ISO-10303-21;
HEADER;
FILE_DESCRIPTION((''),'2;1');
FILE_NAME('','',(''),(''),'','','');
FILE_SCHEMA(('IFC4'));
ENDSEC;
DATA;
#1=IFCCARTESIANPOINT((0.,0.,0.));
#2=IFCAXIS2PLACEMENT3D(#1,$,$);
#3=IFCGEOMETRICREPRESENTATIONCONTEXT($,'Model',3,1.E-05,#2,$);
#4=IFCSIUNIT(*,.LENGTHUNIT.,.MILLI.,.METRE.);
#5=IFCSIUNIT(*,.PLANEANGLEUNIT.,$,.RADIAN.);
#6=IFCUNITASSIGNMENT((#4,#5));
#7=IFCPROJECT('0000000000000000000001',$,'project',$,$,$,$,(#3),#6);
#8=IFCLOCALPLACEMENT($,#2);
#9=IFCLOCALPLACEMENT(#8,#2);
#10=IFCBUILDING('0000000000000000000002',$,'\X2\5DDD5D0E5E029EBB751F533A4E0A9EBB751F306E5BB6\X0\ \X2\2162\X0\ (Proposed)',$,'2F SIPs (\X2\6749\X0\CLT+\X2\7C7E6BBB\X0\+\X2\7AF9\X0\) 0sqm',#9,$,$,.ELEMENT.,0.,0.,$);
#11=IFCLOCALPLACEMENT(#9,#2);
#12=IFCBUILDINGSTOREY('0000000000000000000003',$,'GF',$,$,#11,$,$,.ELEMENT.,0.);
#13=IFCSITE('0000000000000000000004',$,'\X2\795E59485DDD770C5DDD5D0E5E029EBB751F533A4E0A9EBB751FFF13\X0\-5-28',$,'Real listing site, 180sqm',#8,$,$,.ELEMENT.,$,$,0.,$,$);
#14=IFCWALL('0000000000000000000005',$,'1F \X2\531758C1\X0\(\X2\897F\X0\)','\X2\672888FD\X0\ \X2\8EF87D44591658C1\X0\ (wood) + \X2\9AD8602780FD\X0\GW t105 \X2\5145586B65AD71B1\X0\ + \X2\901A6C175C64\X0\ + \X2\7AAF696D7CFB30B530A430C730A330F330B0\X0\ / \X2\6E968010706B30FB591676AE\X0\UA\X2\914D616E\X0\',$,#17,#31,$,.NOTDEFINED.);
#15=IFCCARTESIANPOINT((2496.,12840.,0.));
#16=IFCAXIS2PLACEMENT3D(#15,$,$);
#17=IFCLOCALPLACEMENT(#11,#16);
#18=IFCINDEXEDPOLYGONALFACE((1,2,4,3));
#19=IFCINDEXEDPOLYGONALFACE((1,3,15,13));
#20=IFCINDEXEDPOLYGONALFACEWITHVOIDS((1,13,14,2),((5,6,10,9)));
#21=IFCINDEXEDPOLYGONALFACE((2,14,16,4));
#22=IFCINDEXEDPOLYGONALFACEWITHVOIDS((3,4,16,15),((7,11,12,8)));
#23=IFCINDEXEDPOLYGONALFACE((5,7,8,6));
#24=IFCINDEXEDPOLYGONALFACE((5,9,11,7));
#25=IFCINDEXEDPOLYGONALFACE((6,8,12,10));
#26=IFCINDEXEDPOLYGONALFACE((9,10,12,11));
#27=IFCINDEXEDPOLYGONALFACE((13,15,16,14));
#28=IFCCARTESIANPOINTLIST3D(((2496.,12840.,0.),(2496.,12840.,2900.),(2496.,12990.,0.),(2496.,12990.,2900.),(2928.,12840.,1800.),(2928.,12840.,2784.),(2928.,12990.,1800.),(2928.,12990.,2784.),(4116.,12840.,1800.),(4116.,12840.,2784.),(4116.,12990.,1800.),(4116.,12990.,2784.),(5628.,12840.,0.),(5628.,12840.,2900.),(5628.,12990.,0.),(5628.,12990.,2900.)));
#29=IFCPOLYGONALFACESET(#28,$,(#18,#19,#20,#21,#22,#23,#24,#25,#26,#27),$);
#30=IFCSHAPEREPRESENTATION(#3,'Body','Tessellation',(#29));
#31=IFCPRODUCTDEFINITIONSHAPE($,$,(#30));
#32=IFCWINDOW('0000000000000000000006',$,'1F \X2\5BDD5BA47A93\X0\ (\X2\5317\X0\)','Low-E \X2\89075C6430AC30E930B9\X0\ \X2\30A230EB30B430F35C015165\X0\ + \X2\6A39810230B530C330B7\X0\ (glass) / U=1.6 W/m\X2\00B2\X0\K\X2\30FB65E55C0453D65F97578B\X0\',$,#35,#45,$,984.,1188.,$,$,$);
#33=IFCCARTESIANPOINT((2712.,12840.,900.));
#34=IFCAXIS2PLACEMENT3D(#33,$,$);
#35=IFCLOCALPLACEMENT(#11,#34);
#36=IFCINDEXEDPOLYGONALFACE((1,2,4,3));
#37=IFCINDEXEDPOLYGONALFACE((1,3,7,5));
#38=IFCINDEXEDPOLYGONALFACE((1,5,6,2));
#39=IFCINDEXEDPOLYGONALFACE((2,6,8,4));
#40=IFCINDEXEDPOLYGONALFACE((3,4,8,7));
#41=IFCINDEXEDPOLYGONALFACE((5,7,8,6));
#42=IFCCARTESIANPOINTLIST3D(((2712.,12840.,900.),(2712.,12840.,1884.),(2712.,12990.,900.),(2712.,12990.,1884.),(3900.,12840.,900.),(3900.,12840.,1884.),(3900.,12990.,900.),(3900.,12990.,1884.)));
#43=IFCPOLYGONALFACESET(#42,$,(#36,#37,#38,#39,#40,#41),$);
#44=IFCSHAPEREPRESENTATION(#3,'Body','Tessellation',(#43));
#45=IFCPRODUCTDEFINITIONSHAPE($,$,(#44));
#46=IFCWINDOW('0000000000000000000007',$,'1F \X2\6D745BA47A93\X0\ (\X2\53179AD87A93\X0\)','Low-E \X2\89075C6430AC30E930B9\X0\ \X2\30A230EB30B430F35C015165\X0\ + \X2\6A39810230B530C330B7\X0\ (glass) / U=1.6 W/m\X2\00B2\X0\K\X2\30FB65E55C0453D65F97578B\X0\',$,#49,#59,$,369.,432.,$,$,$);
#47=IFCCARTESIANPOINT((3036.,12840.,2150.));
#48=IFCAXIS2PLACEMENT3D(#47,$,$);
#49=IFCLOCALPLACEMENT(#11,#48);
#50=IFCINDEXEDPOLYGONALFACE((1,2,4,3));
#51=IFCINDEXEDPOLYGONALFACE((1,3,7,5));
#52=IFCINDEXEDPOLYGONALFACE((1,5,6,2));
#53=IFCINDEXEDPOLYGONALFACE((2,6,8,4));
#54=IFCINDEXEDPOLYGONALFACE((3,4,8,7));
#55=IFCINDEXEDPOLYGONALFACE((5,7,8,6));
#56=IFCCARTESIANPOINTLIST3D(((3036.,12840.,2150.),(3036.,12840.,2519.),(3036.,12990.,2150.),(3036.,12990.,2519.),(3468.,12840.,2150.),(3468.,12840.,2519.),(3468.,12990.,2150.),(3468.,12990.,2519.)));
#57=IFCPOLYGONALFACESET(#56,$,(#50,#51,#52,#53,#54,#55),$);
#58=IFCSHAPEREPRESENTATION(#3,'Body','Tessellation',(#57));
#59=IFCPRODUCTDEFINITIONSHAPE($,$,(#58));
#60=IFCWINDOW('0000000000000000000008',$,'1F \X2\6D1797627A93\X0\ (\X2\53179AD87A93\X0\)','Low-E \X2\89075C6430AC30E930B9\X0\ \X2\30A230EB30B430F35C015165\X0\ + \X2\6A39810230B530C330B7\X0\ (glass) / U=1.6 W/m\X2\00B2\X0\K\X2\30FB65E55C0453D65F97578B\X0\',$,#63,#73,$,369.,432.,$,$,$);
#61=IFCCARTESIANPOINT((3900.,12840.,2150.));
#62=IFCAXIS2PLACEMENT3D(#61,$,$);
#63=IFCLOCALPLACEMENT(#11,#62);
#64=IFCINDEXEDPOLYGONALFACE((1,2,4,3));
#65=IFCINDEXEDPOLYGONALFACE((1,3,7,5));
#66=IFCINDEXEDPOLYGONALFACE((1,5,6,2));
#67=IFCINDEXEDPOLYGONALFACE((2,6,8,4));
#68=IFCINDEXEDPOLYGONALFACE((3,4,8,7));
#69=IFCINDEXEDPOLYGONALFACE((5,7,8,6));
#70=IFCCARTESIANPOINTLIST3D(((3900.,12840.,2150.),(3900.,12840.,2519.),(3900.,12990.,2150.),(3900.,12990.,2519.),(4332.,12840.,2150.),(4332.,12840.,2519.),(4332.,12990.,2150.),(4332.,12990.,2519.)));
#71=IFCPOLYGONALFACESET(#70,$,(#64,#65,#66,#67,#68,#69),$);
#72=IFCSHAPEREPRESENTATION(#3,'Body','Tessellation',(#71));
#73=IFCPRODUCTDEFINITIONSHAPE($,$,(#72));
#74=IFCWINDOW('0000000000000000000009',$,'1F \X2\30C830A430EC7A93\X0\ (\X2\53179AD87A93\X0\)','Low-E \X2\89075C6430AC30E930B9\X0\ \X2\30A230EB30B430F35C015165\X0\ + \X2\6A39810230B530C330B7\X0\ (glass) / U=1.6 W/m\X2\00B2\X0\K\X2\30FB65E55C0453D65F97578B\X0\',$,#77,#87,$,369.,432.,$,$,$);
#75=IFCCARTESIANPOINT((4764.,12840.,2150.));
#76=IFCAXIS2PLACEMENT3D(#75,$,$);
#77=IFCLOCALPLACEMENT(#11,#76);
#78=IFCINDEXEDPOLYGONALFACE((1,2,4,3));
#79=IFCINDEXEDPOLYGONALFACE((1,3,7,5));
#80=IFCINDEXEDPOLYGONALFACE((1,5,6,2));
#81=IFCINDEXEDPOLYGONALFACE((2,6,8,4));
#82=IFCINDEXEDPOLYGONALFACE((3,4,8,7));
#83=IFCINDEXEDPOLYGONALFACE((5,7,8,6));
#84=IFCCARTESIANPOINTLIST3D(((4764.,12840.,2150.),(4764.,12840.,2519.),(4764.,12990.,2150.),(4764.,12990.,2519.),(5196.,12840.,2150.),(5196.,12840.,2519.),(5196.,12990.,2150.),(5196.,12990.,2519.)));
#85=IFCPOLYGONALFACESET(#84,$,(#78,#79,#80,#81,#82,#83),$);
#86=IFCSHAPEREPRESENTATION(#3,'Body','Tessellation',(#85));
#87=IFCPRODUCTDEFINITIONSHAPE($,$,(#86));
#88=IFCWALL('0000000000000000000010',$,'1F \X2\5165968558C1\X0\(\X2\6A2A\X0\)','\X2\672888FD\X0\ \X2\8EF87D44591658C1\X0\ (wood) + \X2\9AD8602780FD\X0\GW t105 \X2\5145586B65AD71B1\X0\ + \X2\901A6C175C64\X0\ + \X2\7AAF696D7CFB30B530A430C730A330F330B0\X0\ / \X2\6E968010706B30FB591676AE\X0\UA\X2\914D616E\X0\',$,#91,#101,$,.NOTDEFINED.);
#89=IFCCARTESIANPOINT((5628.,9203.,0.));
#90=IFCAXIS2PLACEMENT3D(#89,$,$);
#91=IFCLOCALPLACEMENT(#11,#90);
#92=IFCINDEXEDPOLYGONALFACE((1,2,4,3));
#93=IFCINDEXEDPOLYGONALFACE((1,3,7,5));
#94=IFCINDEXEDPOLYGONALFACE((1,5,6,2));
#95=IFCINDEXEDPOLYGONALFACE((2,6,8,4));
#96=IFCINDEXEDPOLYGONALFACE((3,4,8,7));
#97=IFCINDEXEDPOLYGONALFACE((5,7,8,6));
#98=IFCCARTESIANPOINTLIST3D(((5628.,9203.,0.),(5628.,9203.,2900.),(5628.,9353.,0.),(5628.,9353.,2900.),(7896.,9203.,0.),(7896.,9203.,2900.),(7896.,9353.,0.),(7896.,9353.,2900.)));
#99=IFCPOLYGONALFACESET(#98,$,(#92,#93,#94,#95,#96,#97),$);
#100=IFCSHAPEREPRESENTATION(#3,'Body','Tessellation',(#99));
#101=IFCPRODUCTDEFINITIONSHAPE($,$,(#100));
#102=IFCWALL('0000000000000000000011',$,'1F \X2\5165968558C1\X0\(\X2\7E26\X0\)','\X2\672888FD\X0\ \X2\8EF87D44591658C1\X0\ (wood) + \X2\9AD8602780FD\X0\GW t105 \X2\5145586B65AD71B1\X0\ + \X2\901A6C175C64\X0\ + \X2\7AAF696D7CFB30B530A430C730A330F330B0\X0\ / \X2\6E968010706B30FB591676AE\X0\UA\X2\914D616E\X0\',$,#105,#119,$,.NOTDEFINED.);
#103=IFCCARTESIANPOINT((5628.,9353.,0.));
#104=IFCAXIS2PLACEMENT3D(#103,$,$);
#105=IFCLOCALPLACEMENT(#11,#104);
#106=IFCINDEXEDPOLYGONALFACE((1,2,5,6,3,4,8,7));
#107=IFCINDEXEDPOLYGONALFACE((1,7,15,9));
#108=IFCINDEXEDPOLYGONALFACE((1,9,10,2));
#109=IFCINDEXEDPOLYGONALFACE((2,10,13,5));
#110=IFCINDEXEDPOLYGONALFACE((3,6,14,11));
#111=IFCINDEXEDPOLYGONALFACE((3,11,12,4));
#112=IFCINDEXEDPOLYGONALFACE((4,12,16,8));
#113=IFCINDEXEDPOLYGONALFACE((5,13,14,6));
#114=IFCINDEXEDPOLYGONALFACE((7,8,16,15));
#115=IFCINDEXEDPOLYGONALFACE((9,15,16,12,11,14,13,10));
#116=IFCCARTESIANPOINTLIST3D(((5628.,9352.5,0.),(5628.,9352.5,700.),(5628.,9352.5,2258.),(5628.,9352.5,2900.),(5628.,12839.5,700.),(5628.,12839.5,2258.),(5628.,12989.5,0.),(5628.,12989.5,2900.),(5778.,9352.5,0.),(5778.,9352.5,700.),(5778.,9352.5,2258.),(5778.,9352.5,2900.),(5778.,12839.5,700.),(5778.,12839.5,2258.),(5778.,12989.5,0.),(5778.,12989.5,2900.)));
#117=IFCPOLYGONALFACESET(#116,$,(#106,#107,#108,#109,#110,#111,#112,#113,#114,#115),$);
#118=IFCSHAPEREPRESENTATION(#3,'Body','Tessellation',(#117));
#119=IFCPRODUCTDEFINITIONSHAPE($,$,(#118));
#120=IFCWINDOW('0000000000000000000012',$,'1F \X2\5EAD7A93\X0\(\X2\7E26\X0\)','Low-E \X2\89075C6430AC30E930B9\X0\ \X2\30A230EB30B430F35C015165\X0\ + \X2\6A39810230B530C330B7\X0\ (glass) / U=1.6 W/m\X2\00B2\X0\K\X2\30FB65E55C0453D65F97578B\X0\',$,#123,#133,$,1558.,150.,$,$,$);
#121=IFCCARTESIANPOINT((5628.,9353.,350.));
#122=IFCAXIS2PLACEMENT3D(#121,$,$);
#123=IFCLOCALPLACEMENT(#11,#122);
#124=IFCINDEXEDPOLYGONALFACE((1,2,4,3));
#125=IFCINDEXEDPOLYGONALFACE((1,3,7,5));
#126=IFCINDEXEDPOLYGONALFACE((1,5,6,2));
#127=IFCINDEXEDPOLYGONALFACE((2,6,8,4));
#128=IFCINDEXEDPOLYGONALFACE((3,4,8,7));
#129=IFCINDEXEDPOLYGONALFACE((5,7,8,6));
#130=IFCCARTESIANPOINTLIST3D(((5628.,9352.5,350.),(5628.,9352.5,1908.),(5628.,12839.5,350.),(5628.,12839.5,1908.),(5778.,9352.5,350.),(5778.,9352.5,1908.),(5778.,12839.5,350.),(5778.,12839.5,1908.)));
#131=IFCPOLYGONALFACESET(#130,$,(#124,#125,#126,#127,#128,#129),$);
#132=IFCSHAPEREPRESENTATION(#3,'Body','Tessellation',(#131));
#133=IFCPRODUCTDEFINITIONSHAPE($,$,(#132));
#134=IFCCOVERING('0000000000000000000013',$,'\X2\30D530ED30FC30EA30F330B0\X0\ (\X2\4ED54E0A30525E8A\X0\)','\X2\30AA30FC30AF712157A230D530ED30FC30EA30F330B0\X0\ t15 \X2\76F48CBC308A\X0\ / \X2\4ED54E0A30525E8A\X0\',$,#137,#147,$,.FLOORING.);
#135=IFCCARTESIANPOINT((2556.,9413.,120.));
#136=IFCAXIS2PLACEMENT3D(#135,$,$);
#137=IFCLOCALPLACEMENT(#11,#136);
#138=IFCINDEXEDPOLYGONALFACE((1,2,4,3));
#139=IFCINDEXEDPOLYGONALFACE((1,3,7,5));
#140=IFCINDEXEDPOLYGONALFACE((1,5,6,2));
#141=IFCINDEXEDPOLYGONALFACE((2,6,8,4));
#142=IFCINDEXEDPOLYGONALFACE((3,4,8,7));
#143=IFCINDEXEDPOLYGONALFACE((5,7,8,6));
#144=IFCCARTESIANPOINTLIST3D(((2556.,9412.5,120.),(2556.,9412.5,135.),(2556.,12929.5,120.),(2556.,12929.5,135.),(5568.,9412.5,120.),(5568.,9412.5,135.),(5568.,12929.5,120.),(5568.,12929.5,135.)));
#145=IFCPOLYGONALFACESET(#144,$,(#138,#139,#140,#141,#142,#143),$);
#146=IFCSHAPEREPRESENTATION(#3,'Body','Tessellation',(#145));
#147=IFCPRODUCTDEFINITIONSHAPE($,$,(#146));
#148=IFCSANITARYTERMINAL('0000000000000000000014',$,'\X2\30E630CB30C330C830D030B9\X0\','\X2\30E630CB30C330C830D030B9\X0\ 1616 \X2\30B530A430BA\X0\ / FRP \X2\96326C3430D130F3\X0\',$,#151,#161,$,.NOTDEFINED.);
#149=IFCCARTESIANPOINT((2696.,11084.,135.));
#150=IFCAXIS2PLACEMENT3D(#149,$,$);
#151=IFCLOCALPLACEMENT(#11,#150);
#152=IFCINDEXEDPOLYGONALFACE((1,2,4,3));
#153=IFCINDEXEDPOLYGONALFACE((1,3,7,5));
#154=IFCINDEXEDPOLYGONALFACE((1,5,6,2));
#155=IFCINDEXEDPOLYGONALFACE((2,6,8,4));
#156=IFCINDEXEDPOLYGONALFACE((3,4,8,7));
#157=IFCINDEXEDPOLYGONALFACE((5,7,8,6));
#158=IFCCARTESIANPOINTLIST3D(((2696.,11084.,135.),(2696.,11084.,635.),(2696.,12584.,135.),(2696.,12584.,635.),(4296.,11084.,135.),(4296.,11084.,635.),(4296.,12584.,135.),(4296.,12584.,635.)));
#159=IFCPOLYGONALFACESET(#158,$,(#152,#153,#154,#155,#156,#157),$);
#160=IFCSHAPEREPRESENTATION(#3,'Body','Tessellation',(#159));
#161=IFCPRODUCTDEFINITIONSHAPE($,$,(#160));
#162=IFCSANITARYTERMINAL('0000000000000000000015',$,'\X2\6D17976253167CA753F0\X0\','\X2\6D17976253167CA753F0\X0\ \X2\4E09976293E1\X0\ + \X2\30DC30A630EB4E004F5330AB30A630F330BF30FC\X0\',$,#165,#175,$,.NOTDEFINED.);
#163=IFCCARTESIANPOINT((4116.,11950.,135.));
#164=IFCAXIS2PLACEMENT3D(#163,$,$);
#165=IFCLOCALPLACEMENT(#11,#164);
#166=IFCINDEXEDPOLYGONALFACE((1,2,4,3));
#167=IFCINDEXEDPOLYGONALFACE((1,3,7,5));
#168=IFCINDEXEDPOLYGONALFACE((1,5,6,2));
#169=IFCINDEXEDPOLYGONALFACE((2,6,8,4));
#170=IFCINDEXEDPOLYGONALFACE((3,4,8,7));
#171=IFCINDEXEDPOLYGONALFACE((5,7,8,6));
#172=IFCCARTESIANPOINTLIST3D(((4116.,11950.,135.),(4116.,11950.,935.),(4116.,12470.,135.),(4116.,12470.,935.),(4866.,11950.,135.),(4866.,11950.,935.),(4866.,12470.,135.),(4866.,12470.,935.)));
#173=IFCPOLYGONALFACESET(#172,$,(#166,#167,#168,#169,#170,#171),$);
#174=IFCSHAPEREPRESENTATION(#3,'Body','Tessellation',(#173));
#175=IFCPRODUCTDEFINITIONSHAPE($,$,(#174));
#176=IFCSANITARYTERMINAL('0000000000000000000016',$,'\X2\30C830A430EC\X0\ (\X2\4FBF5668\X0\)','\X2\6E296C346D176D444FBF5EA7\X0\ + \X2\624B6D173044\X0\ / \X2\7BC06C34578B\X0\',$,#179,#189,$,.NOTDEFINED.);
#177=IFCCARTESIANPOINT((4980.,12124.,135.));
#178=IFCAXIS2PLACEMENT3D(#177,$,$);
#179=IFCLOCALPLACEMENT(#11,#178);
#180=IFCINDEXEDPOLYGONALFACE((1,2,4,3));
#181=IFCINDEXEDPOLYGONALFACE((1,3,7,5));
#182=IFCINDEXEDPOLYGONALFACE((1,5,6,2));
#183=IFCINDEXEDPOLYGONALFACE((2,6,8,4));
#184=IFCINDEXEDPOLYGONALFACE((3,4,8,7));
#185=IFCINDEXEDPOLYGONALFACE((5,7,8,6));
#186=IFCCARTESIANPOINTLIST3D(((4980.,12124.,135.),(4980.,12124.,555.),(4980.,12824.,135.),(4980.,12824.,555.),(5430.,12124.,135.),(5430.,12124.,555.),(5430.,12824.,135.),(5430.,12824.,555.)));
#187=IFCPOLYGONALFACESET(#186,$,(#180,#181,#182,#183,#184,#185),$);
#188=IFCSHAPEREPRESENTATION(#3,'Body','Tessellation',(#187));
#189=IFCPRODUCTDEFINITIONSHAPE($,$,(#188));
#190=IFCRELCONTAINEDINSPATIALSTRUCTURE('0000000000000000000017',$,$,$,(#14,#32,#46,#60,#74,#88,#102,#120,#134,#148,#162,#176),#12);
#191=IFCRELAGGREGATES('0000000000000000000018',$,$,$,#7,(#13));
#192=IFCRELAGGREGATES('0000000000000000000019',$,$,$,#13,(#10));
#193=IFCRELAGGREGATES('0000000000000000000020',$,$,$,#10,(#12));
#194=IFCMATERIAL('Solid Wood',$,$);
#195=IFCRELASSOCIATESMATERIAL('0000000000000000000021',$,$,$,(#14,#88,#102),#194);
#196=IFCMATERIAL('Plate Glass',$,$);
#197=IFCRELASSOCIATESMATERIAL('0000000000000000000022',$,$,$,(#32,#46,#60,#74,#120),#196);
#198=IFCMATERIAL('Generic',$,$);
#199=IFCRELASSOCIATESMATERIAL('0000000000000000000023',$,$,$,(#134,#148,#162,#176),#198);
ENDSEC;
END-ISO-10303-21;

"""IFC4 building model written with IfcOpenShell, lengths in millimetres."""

from ifc_helpers import new_model, si_unit, frame, frame_2d, origin, place, context, project, spatial, rectangle, extrude, material, element, fill, save


model = new_model("IFC4")

# Units and contexts
model_context = context("Model", 3, precision=1e-05, world=origin())
ifc_project = project(units=[si_unit("LENGTHUNIT", "METRE", prefix="MILLI"), si_unit("PLANEANGLEUNIT", "RADIAN")], contexts=[model_context])

# Site, building, storey
site_placement = place(None, origin())
site = spatial("IfcSite", under=ifc_project, at=site_placement, Name="神奈川県川崎市麻生区上麻生３-5-28", ObjectType="Real listing site, 180sqm", CompositionType="ELEMENT", RefElevation=0.0)
building_placement = place(site_placement, origin())
building = spatial("IfcBuilding", under=site, at=building_placement, Name="川崎市麻生区上麻生の家 Ⅲ (Proposed)", ObjectType="2F SIPs (杉CLT+籾殻+竹) 0sqm", CompositionType="ELEMENT", ElevationOfRefHeight=0.0, ElevationOfTerrain=0.0)
storey_placement = place(building_placement, origin())
storey = spatial("IfcBuildingStorey", under=building, at=storey_placement, Name="GF", CompositionType="ELEMENT", Elevation=0.0)

# Shared definitions
ifc_material_1 = material(Name="Solid Wood")

# Wall, openings, windows
wall_1_placement = place(storey_placement, frame((2496.0, 12840.0, 0.0)))
wall_1 = element("IfcWall", 1, at=wall_1_placement, inside=storey, material=ifc_material_1, Name="1F 北壁(西)", Description="木製 軸組外壁 (wood) + 高性能GW t105 充填断熱 + 通気層 + 窯業系サイディング / 準耐火・外皮UA配慮", PredefinedType="NOTDEFINED", context=model_context, shape_type="SweptSolid", body=[
    extrude(rectangle(XDim=3132.0, YDim=150.0, at=frame_2d((1566.0, 75.0))), frame((2496.0, 12840.0, 0.0)), (0.0, 0.0, 1.0), 2900.0),
])
opening_1_placement = place(storey_placement, frame((2712.0, 12840.0, 900.0)))
opening_1 = element("IfcOpeningElement", 2, at=opening_1_placement, cuts=wall_1, PredefinedType="NOTDEFINED", context=model_context, shape_type="SweptSolid", body=[
    extrude(rectangle(XDim=1188.0, YDim=150.0, at=frame_2d((594.0, 75.0))), frame((2712.0, 12840.0, 900.0)), (0.0, 0.0, 1.0), 984.0),
])
opening_2_placement = place(storey_placement, frame((3036.0, 12840.0, 2150.0)))
opening_2 = element("IfcOpeningElement", 3, at=opening_2_placement, cuts=wall_1, PredefinedType="NOTDEFINED", context=model_context, shape_type="SweptSolid", body=[
    extrude(rectangle(XDim=432.0, YDim=150.0, at=frame_2d((216.0, 75.0))), frame((3036.0, 12840.0, 2150.0)), (0.0, 0.0, 1.0), 369.0),
])
opening_3_placement = place(storey_placement, frame((3900.0, 12840.0, 2150.0)))
opening_3 = element("IfcOpeningElement", 4, at=opening_3_placement, cuts=wall_1, PredefinedType="NOTDEFINED", context=model_context, shape_type="SweptSolid", body=[
    extrude(rectangle(XDim=432.0, YDim=150.0, at=frame_2d((216.0, 75.0))), frame((3900.0, 12840.0, 2150.0)), (0.0, 0.0, 1.0), 369.0),
])
opening_4_placement = place(storey_placement, frame((4764.0, 12840.0, 2150.0)))
opening_4 = element("IfcOpeningElement", 5, at=opening_4_placement, cuts=wall_1, PredefinedType="NOTDEFINED", context=model_context, shape_type="SweptSolid", body=[
    extrude(rectangle(XDim=432.0, YDim=150.0, at=frame_2d((216.0, 75.0))), frame((4764.0, 12840.0, 2150.0)), (0.0, 0.0, 1.0), 369.0),
])
ifc_material_2 = material(Name="Plate Glass")
window_1_placement = place(storey_placement, frame((2712.0, 12840.0, 900.0)))
window_1 = element("IfcWindow", 6, at=window_1_placement, inside=storey, material=ifc_material_2, Name="1F 寝室窓 (北)", Description="Low-E 複層ガラス アルゴン封入 + 樹脂サッシ (glass) / U=1.6 W/m²K・日射取得型", OverallHeight=984.0, OverallWidth=1188.0, context=model_context, shape_type="SweptSolid", body=[
    extrude(rectangle(XDim=1188.0, YDim=150.0, at=frame_2d((594.0, 75.0))), frame((2712.0, 12840.0, 900.0)), (0.0, 0.0, 1.0), 984.0),
])
fill(opening_1, window_1)
window_2_placement = place(storey_placement, frame((3036.0, 12840.0, 2150.0)))
window_2 = element("IfcWindow", 7, at=window_2_placement, inside=storey, material=ifc_material_2, Name="1F 浴室窓 (北高窓)", Description="Low-E 複層ガラス アルゴン封入 + 樹脂サッシ (glass) / U=1.6 W/m²K・日射取得型", OverallHeight=369.0, OverallWidth=432.0, context=model_context, shape_type="SweptSolid", body=[
    extrude(rectangle(XDim=432.0, YDim=150.0, at=frame_2d((216.0, 75.0))), frame((3036.0, 12840.0, 2150.0)), (0.0, 0.0, 1.0), 369.0),
])
fill(opening_2, window_2)
window_3_placement = place(storey_placement, frame((3900.0, 12840.0, 2150.0)))
window_3 = element("IfcWindow", 8, at=window_3_placement, inside=storey, material=ifc_material_2, Name="1F 洗面窓 (北高窓)", Description="Low-E 複層ガラス アルゴン封入 + 樹脂サッシ (glass) / U=1.6 W/m²K・日射取得型", OverallHeight=369.0, OverallWidth=432.0, context=model_context, shape_type="SweptSolid", body=[
    extrude(rectangle(XDim=432.0, YDim=150.0, at=frame_2d((216.0, 75.0))), frame((3900.0, 12840.0, 2150.0)), (0.0, 0.0, 1.0), 369.0),
])
fill(opening_3, window_3)
window_4_placement = place(storey_placement, frame((4764.0, 12840.0, 2150.0)))
window_4 = element("IfcWindow", 9, at=window_4_placement, inside=storey, material=ifc_material_2, Name="1F トイレ窓 (北高窓)", Description="Low-E 複層ガラス アルゴン封入 + 樹脂サッシ (glass) / U=1.6 W/m²K・日射取得型", OverallHeight=369.0, OverallWidth=432.0, context=model_context, shape_type="SweptSolid", body=[
    extrude(rectangle(XDim=432.0, YDim=150.0, at=frame_2d((216.0, 75.0))), frame((4764.0, 12840.0, 2150.0)), (0.0, 0.0, 1.0), 369.0),
])
fill(opening_4, window_4)

# Wall
wall_2_placement = place(storey_placement, frame((5628.0, 9203.0, 0.0)))
element("IfcWall", 10, at=wall_2_placement, inside=storey, material=ifc_material_1, Name="1F 入隅壁(横)", Description="木製 軸組外壁 (wood) + 高性能GW t105 充填断熱 + 通気層 + 窯業系サイディング / 準耐火・外皮UA配慮", PredefinedType="NOTDEFINED", context=model_context, shape_type="SweptSolid", body=[
    extrude(rectangle(XDim=2268.0, YDim=150.0, at=frame_2d((1134.0, 75.0))), frame((5628.0, 9203.0, 0.0)), (0.0, 0.0, 1.0), 2900.0),
])

# Wall, opening, window
wall_3_placement = place(storey_placement, frame((5628.0, 9353.0, 0.0)))
wall_3 = element("IfcWall", 11, at=wall_3_placement, inside=storey, material=ifc_material_1, Name="1F 入隅壁(縦)", Description="木製 軸組外壁 (wood) + 高性能GW t105 充填断熱 + 通気層 + 窯業系サイディング / 準耐火・外皮UA配慮", PredefinedType="NOTDEFINED", context=model_context, shape_type="SweptSolid", body=[
    extrude(rectangle(XDim=150.0, YDim=3637.0, at=frame_2d((75.0, 1818.0))), frame((5628.0, 9353.0, 0.0)), (0.0, 0.0, 1.0), 2900.0),
])
opening_5_placement = place(storey_placement, frame((5628.0, 9353.0, 350.0)))
opening_5 = element("IfcOpeningElement", 12, at=opening_5_placement, cuts=wall_3, PredefinedType="NOTDEFINED", context=model_context, shape_type="SweptSolid", body=[
    extrude(rectangle(XDim=150.0, YDim=3487.0, at=frame_2d((75.0, 1743.0))), frame((5628.0, 9353.0, 350.0)), (0.0, 0.0, 1.0), 1558.0),
])
window_5_placement = place(storey_placement, frame((5628.0, 9353.0, 350.0)))
window_5 = element("IfcWindow", 13, at=window_5_placement, inside=storey, material=ifc_material_2, Name="1F 庭窓(縦)", Description="Low-E 複層ガラス アルゴン封入 + 樹脂サッシ (glass) / U=1.6 W/m²K・日射取得型", OverallHeight=1558.0, OverallWidth=150.0, context=model_context, shape_type="SweptSolid", body=[
    extrude(rectangle(XDim=150.0, YDim=3487.0, at=frame_2d((75.0, 1743.0))), frame((5628.0, 9353.0, 350.0)), (0.0, 0.0, 1.0), 1558.0),
])
fill(opening_5, window_5)

# Covering
ifc_material_3 = material(Name="Generic")
covering_placement = place(storey_placement, frame((2556.0, 9413.0, 120.0)))
element("IfcCovering", 14, at=covering_placement, inside=storey, material=ifc_material_3, Name="フローリング (仕上げ床)", Description="オーク無垢フローリング t15 直貼り / 仕上げ床", PredefinedType="FLOORING", context=model_context, shape_type="SweptSolid", body=[
    extrude(rectangle(XDim=3012.0, YDim=3517.0, at=frame_2d((1506.0, 1758.0))), frame((2556.0, 9413.0, 120.0)), (0.0, 0.0, 1.0), 15.0),
])

# Sanitary terminals
sanitary_terminal_1_placement = place(storey_placement, frame((2696.0, 11084.0, 135.0)))
element("IfcSanitaryTerminal", 15, at=sanitary_terminal_1_placement, inside=storey, material=ifc_material_3, Name="ユニットバス", Description="ユニットバス 1616 サイズ / FRP 防水パン", PredefinedType="NOTDEFINED", context=model_context, shape_type="SweptSolid", body=[
    extrude(rectangle(XDim=1600.0, YDim=1500.0, at=frame_2d((800.0, 750.0))), frame((2696.0, 11084.0, 135.0)), (0.0, 0.0, 1.0), 500.0),
])
sanitary_terminal_2_placement = place(storey_placement, frame((4116.0, 11950.0, 135.0)))
element("IfcSanitaryTerminal", 16, at=sanitary_terminal_2_placement, inside=storey, material=ifc_material_3, Name="洗面化粧台", Description="洗面化粧台 三面鏡 + ボウル一体カウンター", PredefinedType="NOTDEFINED", context=model_context, shape_type="SweptSolid", body=[
    extrude(rectangle(XDim=750.0, YDim=520.0, at=frame_2d((375.0, 260.0))), frame((4116.0, 11950.0, 135.0)), (0.0, 0.0, 1.0), 800.0),
])
sanitary_terminal_3_placement = place(storey_placement, frame((4980.0, 12124.0, 135.0)))
element("IfcSanitaryTerminal", 17, at=sanitary_terminal_3_placement, inside=storey, material=ifc_material_3, Name="トイレ (便器)", Description="温水洗浄便座 + 手洗い / 節水型", PredefinedType="NOTDEFINED", context=model_context, shape_type="SweptSolid", body=[
    extrude(rectangle(XDim=450.0, YDim=700.0, at=frame_2d((225.0, 350.0))), frame((4980.0, 12124.0, 135.0)), (0.0, 0.0, 1.0), 420.0),
])

save(model, "model.ifc")
